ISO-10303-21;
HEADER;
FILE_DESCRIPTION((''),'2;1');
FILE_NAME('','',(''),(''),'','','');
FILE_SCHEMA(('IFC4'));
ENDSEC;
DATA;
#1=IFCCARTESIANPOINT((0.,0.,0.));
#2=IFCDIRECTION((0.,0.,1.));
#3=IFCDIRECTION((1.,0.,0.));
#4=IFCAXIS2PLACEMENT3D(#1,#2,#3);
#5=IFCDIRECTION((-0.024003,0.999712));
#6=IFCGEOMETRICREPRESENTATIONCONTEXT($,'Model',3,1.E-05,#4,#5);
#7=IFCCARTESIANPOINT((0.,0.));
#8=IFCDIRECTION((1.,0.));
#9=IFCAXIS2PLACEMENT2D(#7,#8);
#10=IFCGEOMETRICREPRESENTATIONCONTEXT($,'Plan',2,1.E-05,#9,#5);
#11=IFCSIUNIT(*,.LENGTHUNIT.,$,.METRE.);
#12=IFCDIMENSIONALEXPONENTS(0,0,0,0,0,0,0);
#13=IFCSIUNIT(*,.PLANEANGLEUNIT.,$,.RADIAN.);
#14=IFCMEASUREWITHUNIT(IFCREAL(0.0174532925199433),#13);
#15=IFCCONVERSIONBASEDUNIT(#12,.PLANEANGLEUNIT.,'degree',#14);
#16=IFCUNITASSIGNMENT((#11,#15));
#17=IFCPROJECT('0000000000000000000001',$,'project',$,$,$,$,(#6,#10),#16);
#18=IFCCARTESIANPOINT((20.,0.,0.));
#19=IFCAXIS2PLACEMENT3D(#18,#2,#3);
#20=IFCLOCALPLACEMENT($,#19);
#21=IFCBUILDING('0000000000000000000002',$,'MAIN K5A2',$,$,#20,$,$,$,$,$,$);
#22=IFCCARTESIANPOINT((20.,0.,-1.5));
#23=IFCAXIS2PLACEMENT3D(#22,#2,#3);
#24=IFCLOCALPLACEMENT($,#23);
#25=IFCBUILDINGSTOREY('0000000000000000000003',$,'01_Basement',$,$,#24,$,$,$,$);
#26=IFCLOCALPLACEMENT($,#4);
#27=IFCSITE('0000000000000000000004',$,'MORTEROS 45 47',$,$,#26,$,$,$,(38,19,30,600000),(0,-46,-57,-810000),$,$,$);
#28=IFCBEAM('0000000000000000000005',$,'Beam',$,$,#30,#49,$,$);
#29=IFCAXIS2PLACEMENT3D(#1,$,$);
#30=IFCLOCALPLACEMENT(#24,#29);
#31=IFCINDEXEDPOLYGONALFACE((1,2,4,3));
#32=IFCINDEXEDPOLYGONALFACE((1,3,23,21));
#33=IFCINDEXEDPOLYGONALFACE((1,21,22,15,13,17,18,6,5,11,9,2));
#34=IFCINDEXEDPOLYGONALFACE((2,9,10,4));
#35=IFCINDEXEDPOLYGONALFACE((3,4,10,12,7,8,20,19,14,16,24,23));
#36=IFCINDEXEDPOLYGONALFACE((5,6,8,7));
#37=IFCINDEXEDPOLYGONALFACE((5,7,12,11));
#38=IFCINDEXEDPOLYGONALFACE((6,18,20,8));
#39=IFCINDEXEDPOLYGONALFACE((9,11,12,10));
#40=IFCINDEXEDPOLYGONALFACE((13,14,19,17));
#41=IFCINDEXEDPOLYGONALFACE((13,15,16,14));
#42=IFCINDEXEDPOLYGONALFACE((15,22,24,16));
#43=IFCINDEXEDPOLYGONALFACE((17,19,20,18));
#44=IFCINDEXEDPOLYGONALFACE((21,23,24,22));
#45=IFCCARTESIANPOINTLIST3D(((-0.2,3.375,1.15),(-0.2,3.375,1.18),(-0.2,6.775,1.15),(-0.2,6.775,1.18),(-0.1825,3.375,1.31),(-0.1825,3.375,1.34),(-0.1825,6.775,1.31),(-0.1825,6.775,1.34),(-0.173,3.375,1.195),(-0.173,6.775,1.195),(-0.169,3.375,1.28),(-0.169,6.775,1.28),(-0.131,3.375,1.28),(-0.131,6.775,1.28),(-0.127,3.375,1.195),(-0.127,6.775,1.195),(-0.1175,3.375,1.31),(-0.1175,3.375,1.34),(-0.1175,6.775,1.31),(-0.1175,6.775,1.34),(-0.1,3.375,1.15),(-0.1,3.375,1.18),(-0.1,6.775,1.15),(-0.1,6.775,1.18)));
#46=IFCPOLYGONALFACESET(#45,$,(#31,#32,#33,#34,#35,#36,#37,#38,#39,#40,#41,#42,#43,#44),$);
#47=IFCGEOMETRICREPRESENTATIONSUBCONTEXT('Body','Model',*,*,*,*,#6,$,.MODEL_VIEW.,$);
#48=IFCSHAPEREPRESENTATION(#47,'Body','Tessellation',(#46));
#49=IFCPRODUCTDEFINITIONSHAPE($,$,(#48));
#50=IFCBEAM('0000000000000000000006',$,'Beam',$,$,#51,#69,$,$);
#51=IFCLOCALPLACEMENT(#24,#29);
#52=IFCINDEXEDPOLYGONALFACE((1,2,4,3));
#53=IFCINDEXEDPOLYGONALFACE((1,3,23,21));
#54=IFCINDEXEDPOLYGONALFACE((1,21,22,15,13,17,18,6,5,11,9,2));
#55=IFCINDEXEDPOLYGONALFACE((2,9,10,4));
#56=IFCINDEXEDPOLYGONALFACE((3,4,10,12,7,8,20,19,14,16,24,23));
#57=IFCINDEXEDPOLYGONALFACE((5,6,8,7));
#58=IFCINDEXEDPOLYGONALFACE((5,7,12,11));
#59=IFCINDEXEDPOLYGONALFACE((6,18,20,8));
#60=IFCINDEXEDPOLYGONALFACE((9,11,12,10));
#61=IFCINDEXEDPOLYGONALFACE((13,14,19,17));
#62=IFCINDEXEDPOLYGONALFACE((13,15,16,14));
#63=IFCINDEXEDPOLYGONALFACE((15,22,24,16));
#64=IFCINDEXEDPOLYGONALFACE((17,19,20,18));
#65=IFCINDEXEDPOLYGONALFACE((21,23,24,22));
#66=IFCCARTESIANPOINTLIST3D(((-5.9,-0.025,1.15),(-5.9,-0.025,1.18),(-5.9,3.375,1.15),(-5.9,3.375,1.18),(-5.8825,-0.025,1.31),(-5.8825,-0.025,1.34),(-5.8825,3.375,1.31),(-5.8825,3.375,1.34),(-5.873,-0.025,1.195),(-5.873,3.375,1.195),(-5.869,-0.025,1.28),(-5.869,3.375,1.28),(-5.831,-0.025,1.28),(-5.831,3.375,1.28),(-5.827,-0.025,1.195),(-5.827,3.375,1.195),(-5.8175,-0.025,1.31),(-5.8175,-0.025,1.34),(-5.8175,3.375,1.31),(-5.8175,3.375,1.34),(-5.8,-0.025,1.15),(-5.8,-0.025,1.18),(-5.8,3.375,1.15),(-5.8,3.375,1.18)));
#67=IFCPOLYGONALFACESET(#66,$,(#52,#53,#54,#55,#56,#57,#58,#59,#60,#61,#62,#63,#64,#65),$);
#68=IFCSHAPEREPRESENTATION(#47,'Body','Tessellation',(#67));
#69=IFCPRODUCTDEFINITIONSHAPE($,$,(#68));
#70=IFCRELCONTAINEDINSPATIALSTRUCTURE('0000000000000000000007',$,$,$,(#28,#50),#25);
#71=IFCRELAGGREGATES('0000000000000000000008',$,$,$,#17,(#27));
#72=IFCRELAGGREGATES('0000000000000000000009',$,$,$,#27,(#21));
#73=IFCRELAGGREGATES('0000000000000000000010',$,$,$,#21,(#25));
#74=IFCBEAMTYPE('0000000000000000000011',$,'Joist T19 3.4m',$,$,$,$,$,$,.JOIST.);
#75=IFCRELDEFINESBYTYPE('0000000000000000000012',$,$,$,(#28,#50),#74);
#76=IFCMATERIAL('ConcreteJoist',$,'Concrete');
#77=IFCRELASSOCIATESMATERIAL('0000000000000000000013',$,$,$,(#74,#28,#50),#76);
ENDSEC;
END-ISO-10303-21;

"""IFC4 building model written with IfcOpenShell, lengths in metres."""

from ifc_helpers import new_model, entity, si_unit, converted_unit, direction, frame, origin_with_axes, origin_2d_with_axis, place, context, subcontext, project, spatial, indexed_curve, outline, extrude, material, material_profile, profile_set, profile_usage, type_object, element, save


model = new_model("IFC4")

# Units and contexts
model_context = context("Model", 3, precision=1e-05, world=origin_with_axes(), true_north=direction((-0.024003, 0.999712)))
plan_context = context("Plan", 2, precision=1e-05, world=origin_2d_with_axis(), true_north=direction((-0.024003, 0.999712)))
body_context = subcontext(model_context, "Body", "Model", "MODEL_VIEW")
ifc_project = project(units=[si_unit("LENGTHUNIT", "METRE"), converted_unit("PLANEANGLEUNIT", "degree", entity("IfcReal", 0.0174532925199433), si_unit("PLANEANGLEUNIT", "RADIAN"), dimensions=[0, 0, 0, 0, 0, 0, 0])], contexts=[model_context, plan_context])

# Site, building, storey
site_placement = place(None, origin_with_axes())
site = spatial("IfcSite", under=ifc_project, at=site_placement, Name="MORTEROS 45 47", RefLatitude=(38, 19, 30, 600000), RefLongitude=(0, -46, -57, -810000))
building_placement = place(None, frame((20.0, 0.0, 0.0), z_axis=(0.0, 0.0, 1.0), x_axis=(1.0, 0.0, 0.0)))
building = spatial("IfcBuilding", under=site, at=building_placement, Name="MAIN K5A2")
storey_placement = place(None, frame((20.0, 0.0, -1.5), z_axis=(0.0, 0.0, 1.0), x_axis=(1.0, 0.0, 0.0)))
storey = spatial("IfcBuildingStorey", under=building, at=storey_placement, Name="01_Basement")

# Beams
ifc_material = material(Name="ConcreteJoist", Category="Concrete")
ifc_material_profile = material_profile(ifc_material, outline(indexed_curve([(0.019, 0.13), (0.023, 0.045), (0.05, 0.03), (0.05, 0.0), (-0.05, 0.0), (-0.05, 0.03), (-0.023, 0.045), (-0.019, 0.13), (-0.0325, 0.16), (-0.0325, 0.19), (0.0325, 0.19), (0.0325, 0.16), (0.019, 0.13)])))
ifc_profile_set = profile_set([ifc_material_profile], Name="JoistMaterialProfileSet")
beam_type = type_object("IfcBeamType", Name="Joist T19 3.4m", PredefinedType="JOIST", material=ifc_profile_set)
ifc_profile_usage_1 = profile_usage(ifc_profile_set, cardinal=5)
beam_1_placement = place(None, frame((19.85, 3.375, -0.35), z_axis=(0.0, 1.0, 0.0), x_axis=(-1.0, 0.0, 0.0)))
element("IfcBeam", 1, at=beam_1_placement, inside=storey, type_object=beam_type, material=ifc_profile_usage_1, Name="Beam", context=body_context, shape_type="SweptSolid", body=[
    extrude(outline(indexed_curve([(0.019, 0.13), (0.023, 0.045), (0.05, 0.03), (0.05, 0.0), (-0.05, 0.0), (-0.05, 0.03), (-0.023, 0.045), (-0.019, 0.13), (-0.0325, 0.16), (-0.0325, 0.19), (0.0325, 0.19), (0.0325, 0.16), (0.019, 0.13)])), origin_with_axes(), (0.0, 0.0, 1.0), 3.4),
])
ifc_profile_usage_2 = profile_usage(ifc_profile_set, cardinal=5)
beam_2_placement = place(None, frame((14.15, -0.025, -0.35), z_axis=(0.0, 1.0, 0.0), x_axis=(-1.0, 0.0, 0.0)))
element("IfcBeam", 2, at=beam_2_placement, inside=storey, type_object=beam_type, material=ifc_profile_usage_2, Name="Beam", context=body_context, shape_type="SweptSolid", body=[
    extrude(outline(indexed_curve([(0.019, 0.13), (0.023, 0.045), (0.05, 0.03), (0.05, 0.0), (-0.05, 0.0), (-0.05, 0.03), (-0.023, 0.045), (-0.019, 0.13), (-0.0325, 0.16), (-0.0325, 0.19), (0.0325, 0.19), (0.0325, 0.16), (0.019, 0.13)])), origin_with_axes(), (0.0, 0.0, 1.0), 3.4),
])

save(model, "model.ifc")
